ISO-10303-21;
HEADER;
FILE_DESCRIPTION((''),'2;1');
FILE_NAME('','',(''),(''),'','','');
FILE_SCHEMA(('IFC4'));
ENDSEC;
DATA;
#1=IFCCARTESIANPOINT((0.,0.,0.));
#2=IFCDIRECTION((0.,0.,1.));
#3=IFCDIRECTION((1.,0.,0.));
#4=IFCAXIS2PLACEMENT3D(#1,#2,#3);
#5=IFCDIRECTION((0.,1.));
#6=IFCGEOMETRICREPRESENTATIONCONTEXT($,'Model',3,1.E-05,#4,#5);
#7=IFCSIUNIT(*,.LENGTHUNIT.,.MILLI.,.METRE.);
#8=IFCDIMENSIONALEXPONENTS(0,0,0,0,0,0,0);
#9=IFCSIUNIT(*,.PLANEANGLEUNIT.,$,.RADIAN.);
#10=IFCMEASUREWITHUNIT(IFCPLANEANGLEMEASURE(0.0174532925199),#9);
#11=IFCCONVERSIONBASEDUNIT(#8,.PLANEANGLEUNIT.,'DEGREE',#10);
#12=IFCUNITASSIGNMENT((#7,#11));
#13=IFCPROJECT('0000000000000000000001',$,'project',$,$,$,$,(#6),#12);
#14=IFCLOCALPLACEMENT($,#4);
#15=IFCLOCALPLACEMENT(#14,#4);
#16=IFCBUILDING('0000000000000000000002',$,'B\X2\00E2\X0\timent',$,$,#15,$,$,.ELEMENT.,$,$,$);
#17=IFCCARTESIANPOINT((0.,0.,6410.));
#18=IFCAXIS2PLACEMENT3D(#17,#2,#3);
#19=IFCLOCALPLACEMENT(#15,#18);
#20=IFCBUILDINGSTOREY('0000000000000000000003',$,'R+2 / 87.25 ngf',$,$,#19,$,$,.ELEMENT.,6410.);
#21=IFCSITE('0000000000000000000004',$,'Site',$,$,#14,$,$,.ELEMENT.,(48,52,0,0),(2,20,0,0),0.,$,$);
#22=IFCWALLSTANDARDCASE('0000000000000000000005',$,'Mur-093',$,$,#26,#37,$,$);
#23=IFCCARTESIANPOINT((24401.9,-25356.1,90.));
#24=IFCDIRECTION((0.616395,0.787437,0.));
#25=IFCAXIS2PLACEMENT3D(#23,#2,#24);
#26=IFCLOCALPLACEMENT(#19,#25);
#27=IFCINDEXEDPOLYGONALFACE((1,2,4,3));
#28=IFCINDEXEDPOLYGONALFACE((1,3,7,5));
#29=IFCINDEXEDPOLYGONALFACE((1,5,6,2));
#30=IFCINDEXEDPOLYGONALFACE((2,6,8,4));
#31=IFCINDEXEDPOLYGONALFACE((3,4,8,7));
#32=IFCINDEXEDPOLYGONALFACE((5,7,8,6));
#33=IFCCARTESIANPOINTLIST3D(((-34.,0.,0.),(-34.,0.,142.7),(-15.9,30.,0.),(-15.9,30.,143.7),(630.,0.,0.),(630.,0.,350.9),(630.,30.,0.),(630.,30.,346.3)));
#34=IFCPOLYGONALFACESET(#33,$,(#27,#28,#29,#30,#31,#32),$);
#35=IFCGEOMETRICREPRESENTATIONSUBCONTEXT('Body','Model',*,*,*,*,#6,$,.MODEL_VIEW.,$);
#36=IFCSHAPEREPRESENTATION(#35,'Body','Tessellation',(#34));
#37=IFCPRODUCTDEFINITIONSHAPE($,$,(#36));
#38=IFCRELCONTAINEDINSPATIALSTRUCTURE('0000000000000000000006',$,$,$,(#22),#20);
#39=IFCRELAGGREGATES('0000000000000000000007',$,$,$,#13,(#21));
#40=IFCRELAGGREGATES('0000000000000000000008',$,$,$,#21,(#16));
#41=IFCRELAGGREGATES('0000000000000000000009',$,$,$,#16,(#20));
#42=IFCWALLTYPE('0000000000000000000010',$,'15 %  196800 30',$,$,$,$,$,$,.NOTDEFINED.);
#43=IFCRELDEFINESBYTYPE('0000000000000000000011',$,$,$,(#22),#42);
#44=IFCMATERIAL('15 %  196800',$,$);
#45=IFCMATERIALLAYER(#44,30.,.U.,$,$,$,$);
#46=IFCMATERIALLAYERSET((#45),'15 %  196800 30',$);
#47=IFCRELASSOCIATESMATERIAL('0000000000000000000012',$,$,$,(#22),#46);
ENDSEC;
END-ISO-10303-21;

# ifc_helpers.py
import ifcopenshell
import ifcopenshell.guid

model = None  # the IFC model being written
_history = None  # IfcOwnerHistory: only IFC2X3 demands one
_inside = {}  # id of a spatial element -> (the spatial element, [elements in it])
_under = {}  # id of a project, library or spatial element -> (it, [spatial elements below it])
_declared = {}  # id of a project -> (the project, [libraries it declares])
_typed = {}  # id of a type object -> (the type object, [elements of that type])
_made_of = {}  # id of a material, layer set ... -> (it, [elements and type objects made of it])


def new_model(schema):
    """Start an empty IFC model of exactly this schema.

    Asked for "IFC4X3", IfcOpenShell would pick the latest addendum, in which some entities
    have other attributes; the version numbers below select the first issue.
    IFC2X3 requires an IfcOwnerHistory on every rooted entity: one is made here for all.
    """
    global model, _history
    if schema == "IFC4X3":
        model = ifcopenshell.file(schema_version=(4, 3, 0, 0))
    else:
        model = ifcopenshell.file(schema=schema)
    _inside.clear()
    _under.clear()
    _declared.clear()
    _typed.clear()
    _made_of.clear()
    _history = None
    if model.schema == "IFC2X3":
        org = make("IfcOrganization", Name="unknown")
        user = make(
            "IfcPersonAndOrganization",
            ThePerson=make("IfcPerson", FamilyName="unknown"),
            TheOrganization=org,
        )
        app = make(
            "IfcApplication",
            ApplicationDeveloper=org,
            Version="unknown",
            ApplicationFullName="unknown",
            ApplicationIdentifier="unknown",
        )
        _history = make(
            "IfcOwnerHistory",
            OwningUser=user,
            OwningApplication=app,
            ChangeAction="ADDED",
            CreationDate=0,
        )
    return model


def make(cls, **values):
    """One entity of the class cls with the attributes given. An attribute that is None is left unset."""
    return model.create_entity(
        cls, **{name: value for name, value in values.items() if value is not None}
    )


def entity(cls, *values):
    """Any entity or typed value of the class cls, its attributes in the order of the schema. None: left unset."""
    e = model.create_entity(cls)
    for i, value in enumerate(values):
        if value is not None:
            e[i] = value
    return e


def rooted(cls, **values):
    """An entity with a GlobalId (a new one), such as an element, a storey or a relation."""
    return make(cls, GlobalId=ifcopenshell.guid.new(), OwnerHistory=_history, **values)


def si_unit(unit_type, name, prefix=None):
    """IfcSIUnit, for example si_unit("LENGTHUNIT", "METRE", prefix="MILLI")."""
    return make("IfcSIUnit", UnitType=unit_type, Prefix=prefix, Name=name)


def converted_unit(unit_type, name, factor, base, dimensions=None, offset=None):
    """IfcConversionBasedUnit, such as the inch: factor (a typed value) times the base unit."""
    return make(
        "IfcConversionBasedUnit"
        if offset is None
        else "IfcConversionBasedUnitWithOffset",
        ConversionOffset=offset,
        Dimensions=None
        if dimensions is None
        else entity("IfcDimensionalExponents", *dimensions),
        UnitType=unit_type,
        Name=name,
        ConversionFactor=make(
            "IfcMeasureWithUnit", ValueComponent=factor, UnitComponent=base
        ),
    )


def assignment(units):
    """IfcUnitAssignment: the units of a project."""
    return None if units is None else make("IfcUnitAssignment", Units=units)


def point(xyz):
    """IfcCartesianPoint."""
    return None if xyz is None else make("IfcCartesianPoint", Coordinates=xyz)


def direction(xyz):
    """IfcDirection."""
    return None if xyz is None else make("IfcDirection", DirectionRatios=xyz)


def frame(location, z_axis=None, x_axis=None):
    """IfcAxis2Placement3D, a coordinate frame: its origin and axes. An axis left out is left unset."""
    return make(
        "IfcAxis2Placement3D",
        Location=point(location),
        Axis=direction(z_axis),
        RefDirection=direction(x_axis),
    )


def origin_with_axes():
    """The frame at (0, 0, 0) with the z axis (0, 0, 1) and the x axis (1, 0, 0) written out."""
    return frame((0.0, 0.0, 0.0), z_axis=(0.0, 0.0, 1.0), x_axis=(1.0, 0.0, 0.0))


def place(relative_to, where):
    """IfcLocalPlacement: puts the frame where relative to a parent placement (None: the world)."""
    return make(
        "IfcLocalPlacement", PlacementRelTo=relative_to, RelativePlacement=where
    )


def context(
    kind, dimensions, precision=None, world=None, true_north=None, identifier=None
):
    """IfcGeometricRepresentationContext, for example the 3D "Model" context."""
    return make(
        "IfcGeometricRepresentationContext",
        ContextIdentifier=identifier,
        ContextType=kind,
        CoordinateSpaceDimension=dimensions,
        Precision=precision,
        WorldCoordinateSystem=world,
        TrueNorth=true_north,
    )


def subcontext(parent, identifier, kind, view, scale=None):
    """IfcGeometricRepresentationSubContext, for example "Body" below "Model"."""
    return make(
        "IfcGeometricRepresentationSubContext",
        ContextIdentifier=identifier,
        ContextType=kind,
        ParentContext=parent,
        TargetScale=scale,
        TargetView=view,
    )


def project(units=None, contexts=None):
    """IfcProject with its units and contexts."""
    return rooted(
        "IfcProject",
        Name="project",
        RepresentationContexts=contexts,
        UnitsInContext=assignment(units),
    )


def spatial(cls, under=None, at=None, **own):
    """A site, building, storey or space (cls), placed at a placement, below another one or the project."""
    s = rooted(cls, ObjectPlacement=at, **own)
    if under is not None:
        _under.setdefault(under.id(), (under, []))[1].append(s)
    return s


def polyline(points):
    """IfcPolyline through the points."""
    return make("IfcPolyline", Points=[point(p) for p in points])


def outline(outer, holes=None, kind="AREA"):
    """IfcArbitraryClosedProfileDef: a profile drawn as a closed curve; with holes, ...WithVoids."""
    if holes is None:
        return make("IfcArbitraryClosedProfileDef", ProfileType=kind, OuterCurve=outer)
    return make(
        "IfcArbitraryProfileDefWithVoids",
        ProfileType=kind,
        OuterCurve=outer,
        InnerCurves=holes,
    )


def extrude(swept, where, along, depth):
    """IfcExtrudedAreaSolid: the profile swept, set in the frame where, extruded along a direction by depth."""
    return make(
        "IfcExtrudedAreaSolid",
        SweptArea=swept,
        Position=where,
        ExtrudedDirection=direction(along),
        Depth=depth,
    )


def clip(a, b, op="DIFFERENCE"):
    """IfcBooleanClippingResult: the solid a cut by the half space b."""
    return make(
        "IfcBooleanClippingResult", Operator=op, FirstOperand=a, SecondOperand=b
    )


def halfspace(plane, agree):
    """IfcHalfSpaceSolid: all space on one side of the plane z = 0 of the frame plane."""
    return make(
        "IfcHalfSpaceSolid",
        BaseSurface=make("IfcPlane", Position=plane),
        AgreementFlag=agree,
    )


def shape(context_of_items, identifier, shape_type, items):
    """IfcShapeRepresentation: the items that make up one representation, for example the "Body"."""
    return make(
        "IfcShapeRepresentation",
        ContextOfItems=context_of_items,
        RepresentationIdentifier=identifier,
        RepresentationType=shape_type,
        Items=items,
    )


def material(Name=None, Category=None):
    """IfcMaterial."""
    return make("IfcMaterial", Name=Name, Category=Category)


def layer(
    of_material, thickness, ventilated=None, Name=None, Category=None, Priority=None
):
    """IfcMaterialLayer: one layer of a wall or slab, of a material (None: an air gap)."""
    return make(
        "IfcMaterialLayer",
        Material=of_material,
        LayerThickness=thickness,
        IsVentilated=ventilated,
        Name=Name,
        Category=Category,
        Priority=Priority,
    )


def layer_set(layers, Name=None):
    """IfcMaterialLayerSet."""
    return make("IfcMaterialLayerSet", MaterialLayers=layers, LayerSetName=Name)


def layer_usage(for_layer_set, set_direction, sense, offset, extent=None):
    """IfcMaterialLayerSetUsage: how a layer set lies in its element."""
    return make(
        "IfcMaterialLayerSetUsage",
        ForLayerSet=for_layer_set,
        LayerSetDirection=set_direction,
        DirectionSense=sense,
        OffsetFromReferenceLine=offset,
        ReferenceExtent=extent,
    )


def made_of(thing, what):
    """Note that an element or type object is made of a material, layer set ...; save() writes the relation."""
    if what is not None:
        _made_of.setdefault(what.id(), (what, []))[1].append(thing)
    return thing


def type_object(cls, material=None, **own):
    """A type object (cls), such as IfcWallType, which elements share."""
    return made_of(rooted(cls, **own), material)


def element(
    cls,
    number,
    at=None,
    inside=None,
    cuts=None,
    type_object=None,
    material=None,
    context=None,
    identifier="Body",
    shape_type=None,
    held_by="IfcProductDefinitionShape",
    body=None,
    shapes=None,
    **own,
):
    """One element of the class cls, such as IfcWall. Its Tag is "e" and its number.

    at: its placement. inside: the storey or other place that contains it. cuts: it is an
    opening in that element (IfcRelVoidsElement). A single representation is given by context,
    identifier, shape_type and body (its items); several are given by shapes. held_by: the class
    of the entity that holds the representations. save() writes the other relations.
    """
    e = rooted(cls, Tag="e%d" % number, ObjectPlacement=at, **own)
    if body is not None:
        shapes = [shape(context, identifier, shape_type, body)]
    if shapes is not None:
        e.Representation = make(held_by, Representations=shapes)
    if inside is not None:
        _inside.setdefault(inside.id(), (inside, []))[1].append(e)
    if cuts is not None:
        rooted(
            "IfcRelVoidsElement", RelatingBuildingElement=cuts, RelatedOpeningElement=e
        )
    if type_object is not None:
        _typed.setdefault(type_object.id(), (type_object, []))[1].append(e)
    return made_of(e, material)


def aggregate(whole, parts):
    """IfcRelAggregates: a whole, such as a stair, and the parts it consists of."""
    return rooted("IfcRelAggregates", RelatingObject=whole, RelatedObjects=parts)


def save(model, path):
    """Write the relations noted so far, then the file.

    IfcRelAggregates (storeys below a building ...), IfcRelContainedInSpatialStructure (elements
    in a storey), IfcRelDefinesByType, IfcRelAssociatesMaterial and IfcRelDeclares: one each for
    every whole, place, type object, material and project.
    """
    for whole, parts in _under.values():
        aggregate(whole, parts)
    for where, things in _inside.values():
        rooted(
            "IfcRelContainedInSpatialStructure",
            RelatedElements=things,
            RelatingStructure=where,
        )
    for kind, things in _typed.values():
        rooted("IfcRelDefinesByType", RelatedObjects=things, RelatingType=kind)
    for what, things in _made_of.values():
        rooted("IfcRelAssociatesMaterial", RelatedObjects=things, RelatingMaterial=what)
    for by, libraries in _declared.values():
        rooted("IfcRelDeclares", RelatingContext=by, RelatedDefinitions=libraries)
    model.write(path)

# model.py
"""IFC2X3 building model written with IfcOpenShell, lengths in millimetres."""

from ifc_helpers import new_model, entity, si_unit, converted_unit, direction, frame, origin_with_axes, place, context, subcontext, project, spatial, polyline, outline, extrude, clip, halfspace, material, layer, layer_set, layer_usage, type_object, element, save


model = new_model("IFC2X3")

# Units and contexts
model_context = context("Model", 3, precision=1e-05, world=origin_with_axes(), true_north=direction((0.0, 1.0)))
body_context = subcontext(model_context, "Body", "Model", "MODEL_VIEW")
ifc_project = project(units=[si_unit("LENGTHUNIT", "METRE", prefix="MILLI"), converted_unit("PLANEANGLEUNIT", "DEGREE", entity("IfcPlaneAngleMeasure", 0.0174532925199), si_unit("PLANEANGLEUNIT", "RADIAN"), dimensions=[0, 0, 0, 0, 0, 0, 0])], contexts=[model_context])

# Site, building, storey
site_placement = place(None, origin_with_axes())
site = spatial("IfcSite", under=ifc_project, at=site_placement, Name="Site", CompositionType="ELEMENT", RefLatitude=(48, 52, 0, 0), RefLongitude=(2, 20, 0, 0), RefElevation=0.0)
building_placement = place(site_placement, origin_with_axes())
building = spatial("IfcBuilding", under=site, at=building_placement, Name="Bâtiment", CompositionType="ELEMENT")
storey_placement = place(building_placement, frame((0.0, 0.0, 6410.0), z_axis=(0.0, 0.0, 1.0), x_axis=(1.0, 0.0, 0.0)))
storey = spatial("IfcBuildingStorey", under=building, at=storey_placement, Name="R+2 / 87.25 ngf", CompositionType="ELEMENT", Elevation=6410.0)

# Shared definitions
ifc_material_1 = material(Name="15 %  196800")

# Wall
ifc_layer_1 = layer(ifc_material_1, 30.0, ventilated="UNKNOWN")
ifc_layer_set_1 = layer_set([ifc_layer_1], Name="15 %  196800 30")
ifc_layer_usage_1 = layer_usage(ifc_layer_set_1, "AXIS2", "NEGATIVE", 30.0)
wall_type_1 = type_object("IfcWallType", Name="15 %  196800 30", PredefinedType="NOTDEFINED")
wall_1_placement = place(storey_placement, frame((24401.9, -25356.1, 90.0), z_axis=(0.0, 0.0, 1.0), x_axis=(0.616395, 0.787437, 0.0)))
element("IfcWallStandardCase", 1, at=wall_1_placement, inside=storey, type_object=wall_type_1, material=ifc_layer_usage_1, Name="Mur-093", context=body_context, shape_type="Clipping", body=[
    clip(extrude(outline(polyline([(-34.0, 0.0), (630.0, 0.0), (630.0, 30.0), (-15.9, 30.0), (-34.0, 0.0)])), origin_with_axes(), (0.0, 0.0, 1.0), 590.0), halfspace(frame((-42.8, 21.2, 136.6), z_axis=(0.296048, -0.146584, -0.943858), x_axis=(0.0, 0.988154, -0.153463)), True)),
])

save(model, "model.ifc")
